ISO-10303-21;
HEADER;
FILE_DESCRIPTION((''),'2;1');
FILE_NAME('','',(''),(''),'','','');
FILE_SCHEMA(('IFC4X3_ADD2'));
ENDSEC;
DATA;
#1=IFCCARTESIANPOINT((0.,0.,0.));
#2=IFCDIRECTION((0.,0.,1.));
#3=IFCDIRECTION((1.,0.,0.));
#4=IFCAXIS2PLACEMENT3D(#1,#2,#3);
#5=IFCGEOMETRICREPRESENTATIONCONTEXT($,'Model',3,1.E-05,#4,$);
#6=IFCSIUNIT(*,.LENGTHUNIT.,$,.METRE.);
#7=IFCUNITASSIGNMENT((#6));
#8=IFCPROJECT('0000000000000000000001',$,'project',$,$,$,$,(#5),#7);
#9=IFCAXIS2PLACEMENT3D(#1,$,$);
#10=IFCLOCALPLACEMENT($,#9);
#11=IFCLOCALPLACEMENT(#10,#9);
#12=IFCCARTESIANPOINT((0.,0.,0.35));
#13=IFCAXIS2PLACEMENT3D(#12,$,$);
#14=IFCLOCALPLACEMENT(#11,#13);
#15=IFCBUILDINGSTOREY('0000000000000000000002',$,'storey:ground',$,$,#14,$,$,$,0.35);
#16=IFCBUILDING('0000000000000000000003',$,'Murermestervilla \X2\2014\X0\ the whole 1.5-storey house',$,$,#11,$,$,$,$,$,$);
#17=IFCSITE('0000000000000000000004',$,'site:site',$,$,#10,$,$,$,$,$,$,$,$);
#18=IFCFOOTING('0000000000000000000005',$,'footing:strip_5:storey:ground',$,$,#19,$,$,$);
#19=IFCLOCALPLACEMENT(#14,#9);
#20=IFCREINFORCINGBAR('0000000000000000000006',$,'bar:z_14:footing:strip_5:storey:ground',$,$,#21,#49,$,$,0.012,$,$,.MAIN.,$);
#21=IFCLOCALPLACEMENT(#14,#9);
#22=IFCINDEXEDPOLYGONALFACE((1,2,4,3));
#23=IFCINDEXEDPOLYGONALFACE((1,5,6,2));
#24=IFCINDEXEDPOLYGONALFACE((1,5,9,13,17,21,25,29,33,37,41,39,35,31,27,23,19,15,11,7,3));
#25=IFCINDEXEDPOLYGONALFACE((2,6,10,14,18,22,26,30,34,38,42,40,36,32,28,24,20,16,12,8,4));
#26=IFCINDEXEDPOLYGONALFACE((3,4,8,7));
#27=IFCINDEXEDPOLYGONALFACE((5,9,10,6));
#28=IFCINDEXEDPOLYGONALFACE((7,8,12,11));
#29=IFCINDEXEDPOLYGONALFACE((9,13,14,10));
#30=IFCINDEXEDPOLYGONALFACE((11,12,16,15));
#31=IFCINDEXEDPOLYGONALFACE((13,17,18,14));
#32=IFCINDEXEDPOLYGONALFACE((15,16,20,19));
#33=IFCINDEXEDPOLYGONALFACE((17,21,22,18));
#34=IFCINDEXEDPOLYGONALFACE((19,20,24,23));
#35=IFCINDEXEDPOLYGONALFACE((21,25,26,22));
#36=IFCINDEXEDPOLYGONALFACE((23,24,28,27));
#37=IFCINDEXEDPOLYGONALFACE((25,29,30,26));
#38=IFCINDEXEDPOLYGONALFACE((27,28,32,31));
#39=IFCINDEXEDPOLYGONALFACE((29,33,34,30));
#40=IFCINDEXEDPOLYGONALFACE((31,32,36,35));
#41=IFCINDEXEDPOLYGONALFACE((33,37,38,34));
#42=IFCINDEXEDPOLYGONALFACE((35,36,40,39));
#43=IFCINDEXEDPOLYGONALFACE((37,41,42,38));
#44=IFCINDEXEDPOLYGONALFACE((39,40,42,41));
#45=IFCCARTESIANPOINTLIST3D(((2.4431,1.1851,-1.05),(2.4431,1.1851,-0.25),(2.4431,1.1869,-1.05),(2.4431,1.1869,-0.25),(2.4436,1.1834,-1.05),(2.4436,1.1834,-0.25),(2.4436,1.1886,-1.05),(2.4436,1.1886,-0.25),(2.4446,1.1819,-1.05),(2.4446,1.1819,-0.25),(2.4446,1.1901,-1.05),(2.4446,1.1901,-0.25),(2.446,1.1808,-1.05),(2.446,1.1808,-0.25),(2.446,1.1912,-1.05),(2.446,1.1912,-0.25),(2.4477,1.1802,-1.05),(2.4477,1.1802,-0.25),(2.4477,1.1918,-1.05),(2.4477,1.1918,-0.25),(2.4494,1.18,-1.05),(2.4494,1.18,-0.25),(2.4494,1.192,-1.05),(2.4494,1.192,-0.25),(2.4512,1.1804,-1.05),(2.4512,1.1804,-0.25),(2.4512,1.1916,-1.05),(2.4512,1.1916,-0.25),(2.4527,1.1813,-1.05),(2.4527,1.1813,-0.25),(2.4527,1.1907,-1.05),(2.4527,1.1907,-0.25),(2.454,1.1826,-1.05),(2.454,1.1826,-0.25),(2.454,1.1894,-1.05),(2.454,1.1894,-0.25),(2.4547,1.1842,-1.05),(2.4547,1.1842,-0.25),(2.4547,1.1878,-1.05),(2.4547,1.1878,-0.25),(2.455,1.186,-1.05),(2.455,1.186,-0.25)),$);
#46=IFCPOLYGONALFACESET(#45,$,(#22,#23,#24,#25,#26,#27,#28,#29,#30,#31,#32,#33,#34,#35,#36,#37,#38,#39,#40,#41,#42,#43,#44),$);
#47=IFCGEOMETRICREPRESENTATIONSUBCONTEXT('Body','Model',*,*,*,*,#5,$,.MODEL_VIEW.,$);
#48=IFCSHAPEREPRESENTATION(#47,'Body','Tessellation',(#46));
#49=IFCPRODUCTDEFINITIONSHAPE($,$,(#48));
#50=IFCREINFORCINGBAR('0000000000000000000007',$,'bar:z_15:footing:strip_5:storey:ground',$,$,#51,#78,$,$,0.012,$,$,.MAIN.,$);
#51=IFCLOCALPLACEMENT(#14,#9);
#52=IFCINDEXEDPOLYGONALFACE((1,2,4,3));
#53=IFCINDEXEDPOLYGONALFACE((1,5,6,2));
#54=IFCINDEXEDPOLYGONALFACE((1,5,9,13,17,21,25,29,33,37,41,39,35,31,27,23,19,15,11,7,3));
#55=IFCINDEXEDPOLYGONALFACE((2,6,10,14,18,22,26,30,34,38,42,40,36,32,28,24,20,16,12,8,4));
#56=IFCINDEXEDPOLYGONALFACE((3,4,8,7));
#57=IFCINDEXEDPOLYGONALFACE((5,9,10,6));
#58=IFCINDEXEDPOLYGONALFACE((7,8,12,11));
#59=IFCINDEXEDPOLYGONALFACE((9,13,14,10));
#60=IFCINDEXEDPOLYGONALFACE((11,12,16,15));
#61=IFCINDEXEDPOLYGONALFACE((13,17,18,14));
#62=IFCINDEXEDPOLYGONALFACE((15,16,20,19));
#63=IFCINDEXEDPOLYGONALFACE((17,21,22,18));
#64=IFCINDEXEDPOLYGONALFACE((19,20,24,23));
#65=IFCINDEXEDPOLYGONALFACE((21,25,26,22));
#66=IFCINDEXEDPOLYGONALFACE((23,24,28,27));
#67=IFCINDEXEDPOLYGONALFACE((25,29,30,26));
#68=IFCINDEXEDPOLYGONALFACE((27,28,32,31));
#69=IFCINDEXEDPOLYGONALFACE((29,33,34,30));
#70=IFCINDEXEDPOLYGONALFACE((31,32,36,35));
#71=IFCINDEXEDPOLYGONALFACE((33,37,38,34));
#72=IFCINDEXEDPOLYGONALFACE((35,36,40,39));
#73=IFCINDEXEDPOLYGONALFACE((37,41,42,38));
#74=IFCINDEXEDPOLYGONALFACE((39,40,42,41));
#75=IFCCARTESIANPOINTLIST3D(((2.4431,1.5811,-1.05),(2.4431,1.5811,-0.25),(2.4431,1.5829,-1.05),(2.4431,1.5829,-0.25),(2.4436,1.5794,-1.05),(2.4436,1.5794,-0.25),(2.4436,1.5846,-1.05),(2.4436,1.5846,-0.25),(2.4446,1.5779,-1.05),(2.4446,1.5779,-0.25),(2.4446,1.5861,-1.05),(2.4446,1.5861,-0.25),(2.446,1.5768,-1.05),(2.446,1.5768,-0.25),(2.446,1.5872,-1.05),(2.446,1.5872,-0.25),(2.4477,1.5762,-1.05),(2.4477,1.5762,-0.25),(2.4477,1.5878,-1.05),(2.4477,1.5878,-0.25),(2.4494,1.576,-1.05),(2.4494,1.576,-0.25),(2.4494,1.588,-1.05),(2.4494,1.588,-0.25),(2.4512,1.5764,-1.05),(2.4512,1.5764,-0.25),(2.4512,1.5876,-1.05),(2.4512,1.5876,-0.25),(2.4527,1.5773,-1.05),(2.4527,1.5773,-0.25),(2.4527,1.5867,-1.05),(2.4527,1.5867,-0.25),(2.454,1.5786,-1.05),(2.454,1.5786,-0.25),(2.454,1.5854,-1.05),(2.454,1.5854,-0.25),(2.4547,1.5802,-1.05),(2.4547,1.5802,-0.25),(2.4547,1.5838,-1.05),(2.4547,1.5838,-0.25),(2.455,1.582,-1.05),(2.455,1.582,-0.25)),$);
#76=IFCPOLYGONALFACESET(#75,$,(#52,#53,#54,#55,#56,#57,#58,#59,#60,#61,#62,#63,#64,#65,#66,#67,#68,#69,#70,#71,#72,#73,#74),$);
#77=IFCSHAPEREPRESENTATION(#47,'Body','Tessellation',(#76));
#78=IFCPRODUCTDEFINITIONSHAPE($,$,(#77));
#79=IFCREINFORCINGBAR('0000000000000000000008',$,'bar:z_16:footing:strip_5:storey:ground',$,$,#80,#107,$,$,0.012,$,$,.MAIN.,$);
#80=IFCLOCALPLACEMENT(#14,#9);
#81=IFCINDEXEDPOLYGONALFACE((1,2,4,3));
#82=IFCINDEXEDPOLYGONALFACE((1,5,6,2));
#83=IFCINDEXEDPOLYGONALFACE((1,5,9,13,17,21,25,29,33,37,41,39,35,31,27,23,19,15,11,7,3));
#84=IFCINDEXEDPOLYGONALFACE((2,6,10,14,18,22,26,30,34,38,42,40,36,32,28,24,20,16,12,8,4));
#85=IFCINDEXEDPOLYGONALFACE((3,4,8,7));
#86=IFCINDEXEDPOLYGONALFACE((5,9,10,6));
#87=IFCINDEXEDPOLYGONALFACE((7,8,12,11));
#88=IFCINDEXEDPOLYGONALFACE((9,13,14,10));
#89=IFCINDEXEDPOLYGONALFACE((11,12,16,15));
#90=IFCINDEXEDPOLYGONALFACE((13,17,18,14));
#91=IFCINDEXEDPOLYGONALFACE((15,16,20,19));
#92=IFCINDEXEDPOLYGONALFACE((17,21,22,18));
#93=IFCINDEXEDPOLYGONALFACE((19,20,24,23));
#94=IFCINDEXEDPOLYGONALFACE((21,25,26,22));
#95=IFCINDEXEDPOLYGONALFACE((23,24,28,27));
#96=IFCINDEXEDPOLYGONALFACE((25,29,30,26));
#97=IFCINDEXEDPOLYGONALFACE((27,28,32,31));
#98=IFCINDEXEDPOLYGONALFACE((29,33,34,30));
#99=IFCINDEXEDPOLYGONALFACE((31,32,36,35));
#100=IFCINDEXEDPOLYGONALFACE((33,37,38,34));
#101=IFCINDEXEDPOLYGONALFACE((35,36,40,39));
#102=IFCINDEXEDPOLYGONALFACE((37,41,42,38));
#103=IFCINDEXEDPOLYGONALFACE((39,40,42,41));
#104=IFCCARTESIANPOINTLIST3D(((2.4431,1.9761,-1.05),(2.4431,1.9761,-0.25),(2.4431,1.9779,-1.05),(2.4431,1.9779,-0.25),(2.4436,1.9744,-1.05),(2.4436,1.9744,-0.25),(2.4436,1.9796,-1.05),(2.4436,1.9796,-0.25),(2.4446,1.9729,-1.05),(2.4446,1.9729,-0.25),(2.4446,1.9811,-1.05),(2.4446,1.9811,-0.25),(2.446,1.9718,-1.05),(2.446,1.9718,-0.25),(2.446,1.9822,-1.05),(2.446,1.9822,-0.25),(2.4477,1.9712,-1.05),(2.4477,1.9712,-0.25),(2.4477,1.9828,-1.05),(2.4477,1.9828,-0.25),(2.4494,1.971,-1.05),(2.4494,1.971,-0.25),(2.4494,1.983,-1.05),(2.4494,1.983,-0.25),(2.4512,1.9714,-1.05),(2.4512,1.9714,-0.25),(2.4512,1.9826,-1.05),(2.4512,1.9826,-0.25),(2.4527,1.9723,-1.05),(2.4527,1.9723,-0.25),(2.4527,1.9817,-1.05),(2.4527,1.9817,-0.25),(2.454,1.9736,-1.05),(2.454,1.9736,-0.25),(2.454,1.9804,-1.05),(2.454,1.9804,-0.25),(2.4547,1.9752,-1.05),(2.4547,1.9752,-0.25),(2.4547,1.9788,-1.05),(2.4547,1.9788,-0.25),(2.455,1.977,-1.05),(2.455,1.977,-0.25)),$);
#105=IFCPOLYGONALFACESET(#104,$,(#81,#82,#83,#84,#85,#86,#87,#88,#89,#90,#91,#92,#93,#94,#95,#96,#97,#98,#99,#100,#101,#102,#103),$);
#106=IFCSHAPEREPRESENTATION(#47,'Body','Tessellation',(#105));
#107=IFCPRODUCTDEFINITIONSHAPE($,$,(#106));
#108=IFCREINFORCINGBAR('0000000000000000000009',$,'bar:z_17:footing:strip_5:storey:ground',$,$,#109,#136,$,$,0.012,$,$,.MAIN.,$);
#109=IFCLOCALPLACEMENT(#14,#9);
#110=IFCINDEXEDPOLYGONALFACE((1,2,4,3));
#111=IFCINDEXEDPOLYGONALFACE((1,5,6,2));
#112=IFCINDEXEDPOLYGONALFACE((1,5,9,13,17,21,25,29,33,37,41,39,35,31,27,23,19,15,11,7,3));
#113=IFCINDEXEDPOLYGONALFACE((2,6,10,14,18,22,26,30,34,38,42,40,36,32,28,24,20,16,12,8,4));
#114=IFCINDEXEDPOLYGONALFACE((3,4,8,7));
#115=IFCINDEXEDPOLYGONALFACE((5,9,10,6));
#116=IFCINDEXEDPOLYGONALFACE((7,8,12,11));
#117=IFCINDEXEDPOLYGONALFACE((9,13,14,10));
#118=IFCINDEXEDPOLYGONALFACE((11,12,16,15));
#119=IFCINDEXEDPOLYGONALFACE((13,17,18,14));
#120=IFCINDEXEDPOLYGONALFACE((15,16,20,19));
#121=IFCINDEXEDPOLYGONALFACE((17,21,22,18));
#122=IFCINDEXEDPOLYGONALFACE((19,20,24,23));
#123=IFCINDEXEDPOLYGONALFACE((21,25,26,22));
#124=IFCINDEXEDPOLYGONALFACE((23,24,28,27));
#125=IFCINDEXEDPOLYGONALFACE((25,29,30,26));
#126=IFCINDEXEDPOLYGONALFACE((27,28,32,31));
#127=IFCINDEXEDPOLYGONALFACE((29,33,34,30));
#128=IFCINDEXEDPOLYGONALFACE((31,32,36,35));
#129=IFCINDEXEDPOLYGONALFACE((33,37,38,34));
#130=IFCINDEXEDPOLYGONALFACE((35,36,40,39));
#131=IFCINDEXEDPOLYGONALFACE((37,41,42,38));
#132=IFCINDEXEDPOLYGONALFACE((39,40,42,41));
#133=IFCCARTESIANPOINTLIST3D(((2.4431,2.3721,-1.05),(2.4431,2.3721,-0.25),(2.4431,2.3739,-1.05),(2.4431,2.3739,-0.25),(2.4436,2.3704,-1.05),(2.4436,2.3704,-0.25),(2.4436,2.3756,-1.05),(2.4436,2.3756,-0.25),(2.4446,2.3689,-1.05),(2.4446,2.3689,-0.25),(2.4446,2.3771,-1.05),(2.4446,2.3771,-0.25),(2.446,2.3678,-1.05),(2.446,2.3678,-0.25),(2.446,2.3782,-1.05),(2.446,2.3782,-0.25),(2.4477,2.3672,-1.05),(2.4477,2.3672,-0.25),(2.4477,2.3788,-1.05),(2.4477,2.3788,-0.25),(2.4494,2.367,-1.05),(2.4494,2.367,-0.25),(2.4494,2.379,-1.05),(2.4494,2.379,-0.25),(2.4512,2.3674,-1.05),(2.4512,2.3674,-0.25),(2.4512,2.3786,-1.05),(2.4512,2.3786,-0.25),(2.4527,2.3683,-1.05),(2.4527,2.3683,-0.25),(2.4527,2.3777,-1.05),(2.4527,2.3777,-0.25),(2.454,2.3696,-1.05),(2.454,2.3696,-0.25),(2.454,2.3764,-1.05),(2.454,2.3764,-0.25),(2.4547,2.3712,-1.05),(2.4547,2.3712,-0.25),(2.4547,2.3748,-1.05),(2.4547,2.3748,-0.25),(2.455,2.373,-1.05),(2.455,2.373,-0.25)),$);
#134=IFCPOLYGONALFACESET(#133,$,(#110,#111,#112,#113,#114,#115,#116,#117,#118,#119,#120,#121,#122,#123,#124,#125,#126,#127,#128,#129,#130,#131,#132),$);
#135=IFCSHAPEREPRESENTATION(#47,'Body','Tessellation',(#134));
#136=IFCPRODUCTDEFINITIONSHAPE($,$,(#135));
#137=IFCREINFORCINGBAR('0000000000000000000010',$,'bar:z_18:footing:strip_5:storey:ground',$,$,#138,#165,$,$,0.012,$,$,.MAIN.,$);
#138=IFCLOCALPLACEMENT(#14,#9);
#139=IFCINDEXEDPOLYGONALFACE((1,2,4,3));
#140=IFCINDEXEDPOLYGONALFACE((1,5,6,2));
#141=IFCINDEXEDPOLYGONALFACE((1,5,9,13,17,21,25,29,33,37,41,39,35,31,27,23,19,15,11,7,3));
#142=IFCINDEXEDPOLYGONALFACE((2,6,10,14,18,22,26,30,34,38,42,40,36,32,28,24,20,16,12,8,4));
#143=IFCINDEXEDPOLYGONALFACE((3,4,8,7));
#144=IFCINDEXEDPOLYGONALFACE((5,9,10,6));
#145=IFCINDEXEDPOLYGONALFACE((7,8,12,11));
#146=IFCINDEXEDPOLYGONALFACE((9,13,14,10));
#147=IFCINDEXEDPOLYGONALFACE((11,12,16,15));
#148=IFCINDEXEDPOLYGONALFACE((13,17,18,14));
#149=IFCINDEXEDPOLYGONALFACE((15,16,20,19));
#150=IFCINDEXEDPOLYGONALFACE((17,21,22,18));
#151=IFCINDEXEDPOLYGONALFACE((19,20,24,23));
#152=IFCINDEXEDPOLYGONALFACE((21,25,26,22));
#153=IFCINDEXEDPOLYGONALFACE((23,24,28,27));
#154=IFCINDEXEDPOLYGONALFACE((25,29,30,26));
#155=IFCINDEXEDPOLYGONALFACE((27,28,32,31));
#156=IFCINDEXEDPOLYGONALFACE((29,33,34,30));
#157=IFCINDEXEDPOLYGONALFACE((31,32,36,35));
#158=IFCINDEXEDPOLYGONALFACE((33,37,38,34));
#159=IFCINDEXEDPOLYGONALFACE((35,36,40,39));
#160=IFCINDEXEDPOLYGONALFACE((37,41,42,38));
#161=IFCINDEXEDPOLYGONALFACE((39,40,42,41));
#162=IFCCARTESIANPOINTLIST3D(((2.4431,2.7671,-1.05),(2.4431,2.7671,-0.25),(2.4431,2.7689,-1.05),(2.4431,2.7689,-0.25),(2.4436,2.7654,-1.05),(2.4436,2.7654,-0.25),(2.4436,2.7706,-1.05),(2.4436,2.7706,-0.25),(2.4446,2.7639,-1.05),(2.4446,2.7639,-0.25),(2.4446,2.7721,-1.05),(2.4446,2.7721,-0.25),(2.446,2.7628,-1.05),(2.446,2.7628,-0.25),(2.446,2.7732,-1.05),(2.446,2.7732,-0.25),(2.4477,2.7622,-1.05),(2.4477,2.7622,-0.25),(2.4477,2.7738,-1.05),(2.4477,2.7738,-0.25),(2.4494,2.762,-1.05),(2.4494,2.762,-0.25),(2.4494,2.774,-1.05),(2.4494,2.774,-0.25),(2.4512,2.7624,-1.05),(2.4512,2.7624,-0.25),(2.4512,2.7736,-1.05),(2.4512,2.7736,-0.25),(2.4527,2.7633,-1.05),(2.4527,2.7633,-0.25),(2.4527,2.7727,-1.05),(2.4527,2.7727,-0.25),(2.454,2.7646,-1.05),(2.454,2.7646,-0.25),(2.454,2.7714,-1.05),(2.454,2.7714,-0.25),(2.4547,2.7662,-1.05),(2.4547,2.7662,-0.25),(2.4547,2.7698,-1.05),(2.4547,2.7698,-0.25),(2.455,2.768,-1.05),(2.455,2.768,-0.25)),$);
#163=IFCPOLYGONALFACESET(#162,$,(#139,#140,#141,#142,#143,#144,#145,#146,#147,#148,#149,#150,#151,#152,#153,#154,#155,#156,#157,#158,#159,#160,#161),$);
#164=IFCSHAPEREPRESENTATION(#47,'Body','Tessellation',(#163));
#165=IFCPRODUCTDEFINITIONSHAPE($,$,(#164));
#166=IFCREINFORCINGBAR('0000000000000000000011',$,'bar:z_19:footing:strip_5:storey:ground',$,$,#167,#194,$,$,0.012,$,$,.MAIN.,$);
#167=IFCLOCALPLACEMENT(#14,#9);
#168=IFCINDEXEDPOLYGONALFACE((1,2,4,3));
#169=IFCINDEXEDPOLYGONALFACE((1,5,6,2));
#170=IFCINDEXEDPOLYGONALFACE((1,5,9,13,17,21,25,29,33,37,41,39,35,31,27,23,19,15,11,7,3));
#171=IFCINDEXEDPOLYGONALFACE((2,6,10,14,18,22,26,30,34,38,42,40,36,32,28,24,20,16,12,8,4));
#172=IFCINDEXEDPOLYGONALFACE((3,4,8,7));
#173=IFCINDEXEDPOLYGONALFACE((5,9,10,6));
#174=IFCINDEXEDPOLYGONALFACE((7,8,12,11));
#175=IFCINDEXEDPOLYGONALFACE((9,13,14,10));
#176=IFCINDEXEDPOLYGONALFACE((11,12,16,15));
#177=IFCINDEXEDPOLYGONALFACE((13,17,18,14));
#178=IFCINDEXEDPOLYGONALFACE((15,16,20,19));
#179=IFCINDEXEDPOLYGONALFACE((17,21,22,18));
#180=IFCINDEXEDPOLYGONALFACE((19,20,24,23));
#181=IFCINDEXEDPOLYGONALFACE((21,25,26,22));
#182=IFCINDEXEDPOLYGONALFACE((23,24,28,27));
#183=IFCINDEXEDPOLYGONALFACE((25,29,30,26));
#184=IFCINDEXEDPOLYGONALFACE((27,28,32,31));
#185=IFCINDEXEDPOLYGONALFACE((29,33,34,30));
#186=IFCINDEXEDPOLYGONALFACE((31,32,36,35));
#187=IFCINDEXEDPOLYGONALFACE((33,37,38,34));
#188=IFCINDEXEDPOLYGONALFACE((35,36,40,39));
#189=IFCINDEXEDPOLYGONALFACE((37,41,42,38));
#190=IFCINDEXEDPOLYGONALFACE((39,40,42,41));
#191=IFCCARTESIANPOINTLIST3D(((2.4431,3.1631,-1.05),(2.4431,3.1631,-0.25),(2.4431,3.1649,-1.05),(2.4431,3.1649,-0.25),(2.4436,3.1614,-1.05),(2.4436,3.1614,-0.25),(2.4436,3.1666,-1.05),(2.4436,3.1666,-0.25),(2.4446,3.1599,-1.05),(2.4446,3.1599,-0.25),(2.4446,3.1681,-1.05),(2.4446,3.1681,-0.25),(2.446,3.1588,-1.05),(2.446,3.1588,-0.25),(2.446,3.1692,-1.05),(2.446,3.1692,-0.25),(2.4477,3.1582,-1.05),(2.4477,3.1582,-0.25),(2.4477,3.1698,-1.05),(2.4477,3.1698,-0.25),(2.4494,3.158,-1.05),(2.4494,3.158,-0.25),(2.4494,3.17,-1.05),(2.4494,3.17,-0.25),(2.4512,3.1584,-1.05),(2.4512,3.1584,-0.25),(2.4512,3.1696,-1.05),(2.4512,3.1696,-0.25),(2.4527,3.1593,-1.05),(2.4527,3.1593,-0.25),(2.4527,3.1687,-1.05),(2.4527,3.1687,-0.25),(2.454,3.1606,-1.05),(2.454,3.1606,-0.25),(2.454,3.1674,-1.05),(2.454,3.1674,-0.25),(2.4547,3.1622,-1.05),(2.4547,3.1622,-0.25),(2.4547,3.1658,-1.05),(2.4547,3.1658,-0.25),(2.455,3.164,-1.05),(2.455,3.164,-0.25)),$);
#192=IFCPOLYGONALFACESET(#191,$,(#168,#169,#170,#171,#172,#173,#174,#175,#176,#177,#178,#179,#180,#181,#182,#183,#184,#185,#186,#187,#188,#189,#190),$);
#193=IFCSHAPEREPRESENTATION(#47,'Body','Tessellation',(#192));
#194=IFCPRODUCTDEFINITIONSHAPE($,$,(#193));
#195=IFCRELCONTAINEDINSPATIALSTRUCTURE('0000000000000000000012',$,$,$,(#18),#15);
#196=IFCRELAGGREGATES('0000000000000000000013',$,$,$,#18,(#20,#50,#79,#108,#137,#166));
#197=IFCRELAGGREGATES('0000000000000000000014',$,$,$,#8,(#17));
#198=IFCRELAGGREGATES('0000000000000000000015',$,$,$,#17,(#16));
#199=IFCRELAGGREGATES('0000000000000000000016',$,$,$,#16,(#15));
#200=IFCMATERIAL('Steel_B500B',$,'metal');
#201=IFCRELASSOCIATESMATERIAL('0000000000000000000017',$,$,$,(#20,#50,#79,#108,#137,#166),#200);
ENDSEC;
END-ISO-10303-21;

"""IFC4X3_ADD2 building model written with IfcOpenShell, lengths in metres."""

from ifc_helpers import new_model, entity, si_unit, frame, origin, origin_with_axes, place, context, subcontext, project, spatial, material, element, aggregate, save


model = new_model("IFC4X3_ADD2")

# Units and contexts
model_context = context("Model", 3, precision=1e-05, world=origin_with_axes())
body_context = subcontext(model_context, "Body", "Model", "MODEL_VIEW")
ifc_project = project(units=[si_unit("LENGTHUNIT", "METRE")], contexts=[model_context])

# Site, building, storey
placement_1 = place(None, origin())
site = spatial("IfcSite", under=ifc_project, at=placement_1, Name="site:site")
building_placement = place(placement_1, origin())
building = spatial("IfcBuilding", under=site, at=building_placement, Name="Murermestervilla — the whole 1.5-storey house")
storey_placement = place(building_placement, frame((0.0, 0.0, 0.35)))
storey = spatial("IfcBuildingStorey", under=building, at=storey_placement, Name="storey:ground", Elevation=0.35)

# Footing, reinforcing bars
placement_2 = place(storey_placement, frame((0.0, 0.0, -0.35)))
ifc_material = material(Name="Steel_B500B", Category="metal")
footing_1 = element("IfcFooting", 1, at=placement_2, inside=storey, Name="footing:strip_5:storey:ground")
reinforcing_bar_1 = element("IfcReinforcingBar", 2, at=placement_1, material=ifc_material, Name="bar:z_14:footing:strip_5:storey:ground", NominalDiameter=0.012, PredefinedType="MAIN", context=body_context, shape_type="AdvancedSweptSolid", body=[
    entity("IfcSweptDiskSolid", entity("IfcPolyline", [entity("IfcCartesianPoint", [2.449, 1.186, -0.7]), entity("IfcCartesianPoint", [2.449, 1.186, 0.1])]), 0.006),
])
reinforcing_bar_2 = element("IfcReinforcingBar", 3, at=placement_1, material=ifc_material, Name="bar:z_15:footing:strip_5:storey:ground", NominalDiameter=0.012, PredefinedType="MAIN", context=body_context, shape_type="AdvancedSweptSolid", body=[
    entity("IfcSweptDiskSolid", entity("IfcPolyline", [entity("IfcCartesianPoint", [2.449, 1.582, -0.7]), entity("IfcCartesianPoint", [2.449, 1.582, 0.1])]), 0.006),
])
reinforcing_bar_3 = element("IfcReinforcingBar", 4, at=placement_1, material=ifc_material, Name="bar:z_16:footing:strip_5:storey:ground", NominalDiameter=0.012, PredefinedType="MAIN", context=body_context, shape_type="AdvancedSweptSolid", body=[
    entity("IfcSweptDiskSolid", entity("IfcPolyline", [entity("IfcCartesianPoint", [2.449, 1.977, -0.7]), entity("IfcCartesianPoint", [2.449, 1.977, 0.1])]), 0.006),
])
reinforcing_bar_4 = element("IfcReinforcingBar", 5, at=placement_1, material=ifc_material, Name="bar:z_17:footing:strip_5:storey:ground", NominalDiameter=0.012, PredefinedType="MAIN", context=body_context, shape_type="AdvancedSweptSolid", body=[
    entity("IfcSweptDiskSolid", entity("IfcPolyline", [entity("IfcCartesianPoint", [2.449, 2.373, -0.7]), entity("IfcCartesianPoint", [2.449, 2.373, 0.1])]), 0.006),
])
reinforcing_bar_5 = element("IfcReinforcingBar", 6, at=placement_1, material=ifc_material, Name="bar:z_18:footing:strip_5:storey:ground", NominalDiameter=0.012, PredefinedType="MAIN", context=body_context, shape_type="AdvancedSweptSolid", body=[
    entity("IfcSweptDiskSolid", entity("IfcPolyline", [entity("IfcCartesianPoint", [2.449, 2.768, -0.7]), entity("IfcCartesianPoint", [2.449, 2.768, 0.1])]), 0.006),
])
reinforcing_bar_6 = element("IfcReinforcingBar", 7, at=placement_1, material=ifc_material, Name="bar:z_19:footing:strip_5:storey:ground", NominalDiameter=0.012, PredefinedType="MAIN", context=body_context, shape_type="AdvancedSweptSolid", body=[
    entity("IfcSweptDiskSolid", entity("IfcPolyline", [entity("IfcCartesianPoint", [2.449, 3.164, -0.7]), entity("IfcCartesianPoint", [2.449, 3.164, 0.1])]), 0.006),
])
aggregate(footing_1, [reinforcing_bar_1, reinforcing_bar_2, reinforcing_bar_3, reinforcing_bar_4, reinforcing_bar_5, reinforcing_bar_6])

save(model, "model.ifc")
